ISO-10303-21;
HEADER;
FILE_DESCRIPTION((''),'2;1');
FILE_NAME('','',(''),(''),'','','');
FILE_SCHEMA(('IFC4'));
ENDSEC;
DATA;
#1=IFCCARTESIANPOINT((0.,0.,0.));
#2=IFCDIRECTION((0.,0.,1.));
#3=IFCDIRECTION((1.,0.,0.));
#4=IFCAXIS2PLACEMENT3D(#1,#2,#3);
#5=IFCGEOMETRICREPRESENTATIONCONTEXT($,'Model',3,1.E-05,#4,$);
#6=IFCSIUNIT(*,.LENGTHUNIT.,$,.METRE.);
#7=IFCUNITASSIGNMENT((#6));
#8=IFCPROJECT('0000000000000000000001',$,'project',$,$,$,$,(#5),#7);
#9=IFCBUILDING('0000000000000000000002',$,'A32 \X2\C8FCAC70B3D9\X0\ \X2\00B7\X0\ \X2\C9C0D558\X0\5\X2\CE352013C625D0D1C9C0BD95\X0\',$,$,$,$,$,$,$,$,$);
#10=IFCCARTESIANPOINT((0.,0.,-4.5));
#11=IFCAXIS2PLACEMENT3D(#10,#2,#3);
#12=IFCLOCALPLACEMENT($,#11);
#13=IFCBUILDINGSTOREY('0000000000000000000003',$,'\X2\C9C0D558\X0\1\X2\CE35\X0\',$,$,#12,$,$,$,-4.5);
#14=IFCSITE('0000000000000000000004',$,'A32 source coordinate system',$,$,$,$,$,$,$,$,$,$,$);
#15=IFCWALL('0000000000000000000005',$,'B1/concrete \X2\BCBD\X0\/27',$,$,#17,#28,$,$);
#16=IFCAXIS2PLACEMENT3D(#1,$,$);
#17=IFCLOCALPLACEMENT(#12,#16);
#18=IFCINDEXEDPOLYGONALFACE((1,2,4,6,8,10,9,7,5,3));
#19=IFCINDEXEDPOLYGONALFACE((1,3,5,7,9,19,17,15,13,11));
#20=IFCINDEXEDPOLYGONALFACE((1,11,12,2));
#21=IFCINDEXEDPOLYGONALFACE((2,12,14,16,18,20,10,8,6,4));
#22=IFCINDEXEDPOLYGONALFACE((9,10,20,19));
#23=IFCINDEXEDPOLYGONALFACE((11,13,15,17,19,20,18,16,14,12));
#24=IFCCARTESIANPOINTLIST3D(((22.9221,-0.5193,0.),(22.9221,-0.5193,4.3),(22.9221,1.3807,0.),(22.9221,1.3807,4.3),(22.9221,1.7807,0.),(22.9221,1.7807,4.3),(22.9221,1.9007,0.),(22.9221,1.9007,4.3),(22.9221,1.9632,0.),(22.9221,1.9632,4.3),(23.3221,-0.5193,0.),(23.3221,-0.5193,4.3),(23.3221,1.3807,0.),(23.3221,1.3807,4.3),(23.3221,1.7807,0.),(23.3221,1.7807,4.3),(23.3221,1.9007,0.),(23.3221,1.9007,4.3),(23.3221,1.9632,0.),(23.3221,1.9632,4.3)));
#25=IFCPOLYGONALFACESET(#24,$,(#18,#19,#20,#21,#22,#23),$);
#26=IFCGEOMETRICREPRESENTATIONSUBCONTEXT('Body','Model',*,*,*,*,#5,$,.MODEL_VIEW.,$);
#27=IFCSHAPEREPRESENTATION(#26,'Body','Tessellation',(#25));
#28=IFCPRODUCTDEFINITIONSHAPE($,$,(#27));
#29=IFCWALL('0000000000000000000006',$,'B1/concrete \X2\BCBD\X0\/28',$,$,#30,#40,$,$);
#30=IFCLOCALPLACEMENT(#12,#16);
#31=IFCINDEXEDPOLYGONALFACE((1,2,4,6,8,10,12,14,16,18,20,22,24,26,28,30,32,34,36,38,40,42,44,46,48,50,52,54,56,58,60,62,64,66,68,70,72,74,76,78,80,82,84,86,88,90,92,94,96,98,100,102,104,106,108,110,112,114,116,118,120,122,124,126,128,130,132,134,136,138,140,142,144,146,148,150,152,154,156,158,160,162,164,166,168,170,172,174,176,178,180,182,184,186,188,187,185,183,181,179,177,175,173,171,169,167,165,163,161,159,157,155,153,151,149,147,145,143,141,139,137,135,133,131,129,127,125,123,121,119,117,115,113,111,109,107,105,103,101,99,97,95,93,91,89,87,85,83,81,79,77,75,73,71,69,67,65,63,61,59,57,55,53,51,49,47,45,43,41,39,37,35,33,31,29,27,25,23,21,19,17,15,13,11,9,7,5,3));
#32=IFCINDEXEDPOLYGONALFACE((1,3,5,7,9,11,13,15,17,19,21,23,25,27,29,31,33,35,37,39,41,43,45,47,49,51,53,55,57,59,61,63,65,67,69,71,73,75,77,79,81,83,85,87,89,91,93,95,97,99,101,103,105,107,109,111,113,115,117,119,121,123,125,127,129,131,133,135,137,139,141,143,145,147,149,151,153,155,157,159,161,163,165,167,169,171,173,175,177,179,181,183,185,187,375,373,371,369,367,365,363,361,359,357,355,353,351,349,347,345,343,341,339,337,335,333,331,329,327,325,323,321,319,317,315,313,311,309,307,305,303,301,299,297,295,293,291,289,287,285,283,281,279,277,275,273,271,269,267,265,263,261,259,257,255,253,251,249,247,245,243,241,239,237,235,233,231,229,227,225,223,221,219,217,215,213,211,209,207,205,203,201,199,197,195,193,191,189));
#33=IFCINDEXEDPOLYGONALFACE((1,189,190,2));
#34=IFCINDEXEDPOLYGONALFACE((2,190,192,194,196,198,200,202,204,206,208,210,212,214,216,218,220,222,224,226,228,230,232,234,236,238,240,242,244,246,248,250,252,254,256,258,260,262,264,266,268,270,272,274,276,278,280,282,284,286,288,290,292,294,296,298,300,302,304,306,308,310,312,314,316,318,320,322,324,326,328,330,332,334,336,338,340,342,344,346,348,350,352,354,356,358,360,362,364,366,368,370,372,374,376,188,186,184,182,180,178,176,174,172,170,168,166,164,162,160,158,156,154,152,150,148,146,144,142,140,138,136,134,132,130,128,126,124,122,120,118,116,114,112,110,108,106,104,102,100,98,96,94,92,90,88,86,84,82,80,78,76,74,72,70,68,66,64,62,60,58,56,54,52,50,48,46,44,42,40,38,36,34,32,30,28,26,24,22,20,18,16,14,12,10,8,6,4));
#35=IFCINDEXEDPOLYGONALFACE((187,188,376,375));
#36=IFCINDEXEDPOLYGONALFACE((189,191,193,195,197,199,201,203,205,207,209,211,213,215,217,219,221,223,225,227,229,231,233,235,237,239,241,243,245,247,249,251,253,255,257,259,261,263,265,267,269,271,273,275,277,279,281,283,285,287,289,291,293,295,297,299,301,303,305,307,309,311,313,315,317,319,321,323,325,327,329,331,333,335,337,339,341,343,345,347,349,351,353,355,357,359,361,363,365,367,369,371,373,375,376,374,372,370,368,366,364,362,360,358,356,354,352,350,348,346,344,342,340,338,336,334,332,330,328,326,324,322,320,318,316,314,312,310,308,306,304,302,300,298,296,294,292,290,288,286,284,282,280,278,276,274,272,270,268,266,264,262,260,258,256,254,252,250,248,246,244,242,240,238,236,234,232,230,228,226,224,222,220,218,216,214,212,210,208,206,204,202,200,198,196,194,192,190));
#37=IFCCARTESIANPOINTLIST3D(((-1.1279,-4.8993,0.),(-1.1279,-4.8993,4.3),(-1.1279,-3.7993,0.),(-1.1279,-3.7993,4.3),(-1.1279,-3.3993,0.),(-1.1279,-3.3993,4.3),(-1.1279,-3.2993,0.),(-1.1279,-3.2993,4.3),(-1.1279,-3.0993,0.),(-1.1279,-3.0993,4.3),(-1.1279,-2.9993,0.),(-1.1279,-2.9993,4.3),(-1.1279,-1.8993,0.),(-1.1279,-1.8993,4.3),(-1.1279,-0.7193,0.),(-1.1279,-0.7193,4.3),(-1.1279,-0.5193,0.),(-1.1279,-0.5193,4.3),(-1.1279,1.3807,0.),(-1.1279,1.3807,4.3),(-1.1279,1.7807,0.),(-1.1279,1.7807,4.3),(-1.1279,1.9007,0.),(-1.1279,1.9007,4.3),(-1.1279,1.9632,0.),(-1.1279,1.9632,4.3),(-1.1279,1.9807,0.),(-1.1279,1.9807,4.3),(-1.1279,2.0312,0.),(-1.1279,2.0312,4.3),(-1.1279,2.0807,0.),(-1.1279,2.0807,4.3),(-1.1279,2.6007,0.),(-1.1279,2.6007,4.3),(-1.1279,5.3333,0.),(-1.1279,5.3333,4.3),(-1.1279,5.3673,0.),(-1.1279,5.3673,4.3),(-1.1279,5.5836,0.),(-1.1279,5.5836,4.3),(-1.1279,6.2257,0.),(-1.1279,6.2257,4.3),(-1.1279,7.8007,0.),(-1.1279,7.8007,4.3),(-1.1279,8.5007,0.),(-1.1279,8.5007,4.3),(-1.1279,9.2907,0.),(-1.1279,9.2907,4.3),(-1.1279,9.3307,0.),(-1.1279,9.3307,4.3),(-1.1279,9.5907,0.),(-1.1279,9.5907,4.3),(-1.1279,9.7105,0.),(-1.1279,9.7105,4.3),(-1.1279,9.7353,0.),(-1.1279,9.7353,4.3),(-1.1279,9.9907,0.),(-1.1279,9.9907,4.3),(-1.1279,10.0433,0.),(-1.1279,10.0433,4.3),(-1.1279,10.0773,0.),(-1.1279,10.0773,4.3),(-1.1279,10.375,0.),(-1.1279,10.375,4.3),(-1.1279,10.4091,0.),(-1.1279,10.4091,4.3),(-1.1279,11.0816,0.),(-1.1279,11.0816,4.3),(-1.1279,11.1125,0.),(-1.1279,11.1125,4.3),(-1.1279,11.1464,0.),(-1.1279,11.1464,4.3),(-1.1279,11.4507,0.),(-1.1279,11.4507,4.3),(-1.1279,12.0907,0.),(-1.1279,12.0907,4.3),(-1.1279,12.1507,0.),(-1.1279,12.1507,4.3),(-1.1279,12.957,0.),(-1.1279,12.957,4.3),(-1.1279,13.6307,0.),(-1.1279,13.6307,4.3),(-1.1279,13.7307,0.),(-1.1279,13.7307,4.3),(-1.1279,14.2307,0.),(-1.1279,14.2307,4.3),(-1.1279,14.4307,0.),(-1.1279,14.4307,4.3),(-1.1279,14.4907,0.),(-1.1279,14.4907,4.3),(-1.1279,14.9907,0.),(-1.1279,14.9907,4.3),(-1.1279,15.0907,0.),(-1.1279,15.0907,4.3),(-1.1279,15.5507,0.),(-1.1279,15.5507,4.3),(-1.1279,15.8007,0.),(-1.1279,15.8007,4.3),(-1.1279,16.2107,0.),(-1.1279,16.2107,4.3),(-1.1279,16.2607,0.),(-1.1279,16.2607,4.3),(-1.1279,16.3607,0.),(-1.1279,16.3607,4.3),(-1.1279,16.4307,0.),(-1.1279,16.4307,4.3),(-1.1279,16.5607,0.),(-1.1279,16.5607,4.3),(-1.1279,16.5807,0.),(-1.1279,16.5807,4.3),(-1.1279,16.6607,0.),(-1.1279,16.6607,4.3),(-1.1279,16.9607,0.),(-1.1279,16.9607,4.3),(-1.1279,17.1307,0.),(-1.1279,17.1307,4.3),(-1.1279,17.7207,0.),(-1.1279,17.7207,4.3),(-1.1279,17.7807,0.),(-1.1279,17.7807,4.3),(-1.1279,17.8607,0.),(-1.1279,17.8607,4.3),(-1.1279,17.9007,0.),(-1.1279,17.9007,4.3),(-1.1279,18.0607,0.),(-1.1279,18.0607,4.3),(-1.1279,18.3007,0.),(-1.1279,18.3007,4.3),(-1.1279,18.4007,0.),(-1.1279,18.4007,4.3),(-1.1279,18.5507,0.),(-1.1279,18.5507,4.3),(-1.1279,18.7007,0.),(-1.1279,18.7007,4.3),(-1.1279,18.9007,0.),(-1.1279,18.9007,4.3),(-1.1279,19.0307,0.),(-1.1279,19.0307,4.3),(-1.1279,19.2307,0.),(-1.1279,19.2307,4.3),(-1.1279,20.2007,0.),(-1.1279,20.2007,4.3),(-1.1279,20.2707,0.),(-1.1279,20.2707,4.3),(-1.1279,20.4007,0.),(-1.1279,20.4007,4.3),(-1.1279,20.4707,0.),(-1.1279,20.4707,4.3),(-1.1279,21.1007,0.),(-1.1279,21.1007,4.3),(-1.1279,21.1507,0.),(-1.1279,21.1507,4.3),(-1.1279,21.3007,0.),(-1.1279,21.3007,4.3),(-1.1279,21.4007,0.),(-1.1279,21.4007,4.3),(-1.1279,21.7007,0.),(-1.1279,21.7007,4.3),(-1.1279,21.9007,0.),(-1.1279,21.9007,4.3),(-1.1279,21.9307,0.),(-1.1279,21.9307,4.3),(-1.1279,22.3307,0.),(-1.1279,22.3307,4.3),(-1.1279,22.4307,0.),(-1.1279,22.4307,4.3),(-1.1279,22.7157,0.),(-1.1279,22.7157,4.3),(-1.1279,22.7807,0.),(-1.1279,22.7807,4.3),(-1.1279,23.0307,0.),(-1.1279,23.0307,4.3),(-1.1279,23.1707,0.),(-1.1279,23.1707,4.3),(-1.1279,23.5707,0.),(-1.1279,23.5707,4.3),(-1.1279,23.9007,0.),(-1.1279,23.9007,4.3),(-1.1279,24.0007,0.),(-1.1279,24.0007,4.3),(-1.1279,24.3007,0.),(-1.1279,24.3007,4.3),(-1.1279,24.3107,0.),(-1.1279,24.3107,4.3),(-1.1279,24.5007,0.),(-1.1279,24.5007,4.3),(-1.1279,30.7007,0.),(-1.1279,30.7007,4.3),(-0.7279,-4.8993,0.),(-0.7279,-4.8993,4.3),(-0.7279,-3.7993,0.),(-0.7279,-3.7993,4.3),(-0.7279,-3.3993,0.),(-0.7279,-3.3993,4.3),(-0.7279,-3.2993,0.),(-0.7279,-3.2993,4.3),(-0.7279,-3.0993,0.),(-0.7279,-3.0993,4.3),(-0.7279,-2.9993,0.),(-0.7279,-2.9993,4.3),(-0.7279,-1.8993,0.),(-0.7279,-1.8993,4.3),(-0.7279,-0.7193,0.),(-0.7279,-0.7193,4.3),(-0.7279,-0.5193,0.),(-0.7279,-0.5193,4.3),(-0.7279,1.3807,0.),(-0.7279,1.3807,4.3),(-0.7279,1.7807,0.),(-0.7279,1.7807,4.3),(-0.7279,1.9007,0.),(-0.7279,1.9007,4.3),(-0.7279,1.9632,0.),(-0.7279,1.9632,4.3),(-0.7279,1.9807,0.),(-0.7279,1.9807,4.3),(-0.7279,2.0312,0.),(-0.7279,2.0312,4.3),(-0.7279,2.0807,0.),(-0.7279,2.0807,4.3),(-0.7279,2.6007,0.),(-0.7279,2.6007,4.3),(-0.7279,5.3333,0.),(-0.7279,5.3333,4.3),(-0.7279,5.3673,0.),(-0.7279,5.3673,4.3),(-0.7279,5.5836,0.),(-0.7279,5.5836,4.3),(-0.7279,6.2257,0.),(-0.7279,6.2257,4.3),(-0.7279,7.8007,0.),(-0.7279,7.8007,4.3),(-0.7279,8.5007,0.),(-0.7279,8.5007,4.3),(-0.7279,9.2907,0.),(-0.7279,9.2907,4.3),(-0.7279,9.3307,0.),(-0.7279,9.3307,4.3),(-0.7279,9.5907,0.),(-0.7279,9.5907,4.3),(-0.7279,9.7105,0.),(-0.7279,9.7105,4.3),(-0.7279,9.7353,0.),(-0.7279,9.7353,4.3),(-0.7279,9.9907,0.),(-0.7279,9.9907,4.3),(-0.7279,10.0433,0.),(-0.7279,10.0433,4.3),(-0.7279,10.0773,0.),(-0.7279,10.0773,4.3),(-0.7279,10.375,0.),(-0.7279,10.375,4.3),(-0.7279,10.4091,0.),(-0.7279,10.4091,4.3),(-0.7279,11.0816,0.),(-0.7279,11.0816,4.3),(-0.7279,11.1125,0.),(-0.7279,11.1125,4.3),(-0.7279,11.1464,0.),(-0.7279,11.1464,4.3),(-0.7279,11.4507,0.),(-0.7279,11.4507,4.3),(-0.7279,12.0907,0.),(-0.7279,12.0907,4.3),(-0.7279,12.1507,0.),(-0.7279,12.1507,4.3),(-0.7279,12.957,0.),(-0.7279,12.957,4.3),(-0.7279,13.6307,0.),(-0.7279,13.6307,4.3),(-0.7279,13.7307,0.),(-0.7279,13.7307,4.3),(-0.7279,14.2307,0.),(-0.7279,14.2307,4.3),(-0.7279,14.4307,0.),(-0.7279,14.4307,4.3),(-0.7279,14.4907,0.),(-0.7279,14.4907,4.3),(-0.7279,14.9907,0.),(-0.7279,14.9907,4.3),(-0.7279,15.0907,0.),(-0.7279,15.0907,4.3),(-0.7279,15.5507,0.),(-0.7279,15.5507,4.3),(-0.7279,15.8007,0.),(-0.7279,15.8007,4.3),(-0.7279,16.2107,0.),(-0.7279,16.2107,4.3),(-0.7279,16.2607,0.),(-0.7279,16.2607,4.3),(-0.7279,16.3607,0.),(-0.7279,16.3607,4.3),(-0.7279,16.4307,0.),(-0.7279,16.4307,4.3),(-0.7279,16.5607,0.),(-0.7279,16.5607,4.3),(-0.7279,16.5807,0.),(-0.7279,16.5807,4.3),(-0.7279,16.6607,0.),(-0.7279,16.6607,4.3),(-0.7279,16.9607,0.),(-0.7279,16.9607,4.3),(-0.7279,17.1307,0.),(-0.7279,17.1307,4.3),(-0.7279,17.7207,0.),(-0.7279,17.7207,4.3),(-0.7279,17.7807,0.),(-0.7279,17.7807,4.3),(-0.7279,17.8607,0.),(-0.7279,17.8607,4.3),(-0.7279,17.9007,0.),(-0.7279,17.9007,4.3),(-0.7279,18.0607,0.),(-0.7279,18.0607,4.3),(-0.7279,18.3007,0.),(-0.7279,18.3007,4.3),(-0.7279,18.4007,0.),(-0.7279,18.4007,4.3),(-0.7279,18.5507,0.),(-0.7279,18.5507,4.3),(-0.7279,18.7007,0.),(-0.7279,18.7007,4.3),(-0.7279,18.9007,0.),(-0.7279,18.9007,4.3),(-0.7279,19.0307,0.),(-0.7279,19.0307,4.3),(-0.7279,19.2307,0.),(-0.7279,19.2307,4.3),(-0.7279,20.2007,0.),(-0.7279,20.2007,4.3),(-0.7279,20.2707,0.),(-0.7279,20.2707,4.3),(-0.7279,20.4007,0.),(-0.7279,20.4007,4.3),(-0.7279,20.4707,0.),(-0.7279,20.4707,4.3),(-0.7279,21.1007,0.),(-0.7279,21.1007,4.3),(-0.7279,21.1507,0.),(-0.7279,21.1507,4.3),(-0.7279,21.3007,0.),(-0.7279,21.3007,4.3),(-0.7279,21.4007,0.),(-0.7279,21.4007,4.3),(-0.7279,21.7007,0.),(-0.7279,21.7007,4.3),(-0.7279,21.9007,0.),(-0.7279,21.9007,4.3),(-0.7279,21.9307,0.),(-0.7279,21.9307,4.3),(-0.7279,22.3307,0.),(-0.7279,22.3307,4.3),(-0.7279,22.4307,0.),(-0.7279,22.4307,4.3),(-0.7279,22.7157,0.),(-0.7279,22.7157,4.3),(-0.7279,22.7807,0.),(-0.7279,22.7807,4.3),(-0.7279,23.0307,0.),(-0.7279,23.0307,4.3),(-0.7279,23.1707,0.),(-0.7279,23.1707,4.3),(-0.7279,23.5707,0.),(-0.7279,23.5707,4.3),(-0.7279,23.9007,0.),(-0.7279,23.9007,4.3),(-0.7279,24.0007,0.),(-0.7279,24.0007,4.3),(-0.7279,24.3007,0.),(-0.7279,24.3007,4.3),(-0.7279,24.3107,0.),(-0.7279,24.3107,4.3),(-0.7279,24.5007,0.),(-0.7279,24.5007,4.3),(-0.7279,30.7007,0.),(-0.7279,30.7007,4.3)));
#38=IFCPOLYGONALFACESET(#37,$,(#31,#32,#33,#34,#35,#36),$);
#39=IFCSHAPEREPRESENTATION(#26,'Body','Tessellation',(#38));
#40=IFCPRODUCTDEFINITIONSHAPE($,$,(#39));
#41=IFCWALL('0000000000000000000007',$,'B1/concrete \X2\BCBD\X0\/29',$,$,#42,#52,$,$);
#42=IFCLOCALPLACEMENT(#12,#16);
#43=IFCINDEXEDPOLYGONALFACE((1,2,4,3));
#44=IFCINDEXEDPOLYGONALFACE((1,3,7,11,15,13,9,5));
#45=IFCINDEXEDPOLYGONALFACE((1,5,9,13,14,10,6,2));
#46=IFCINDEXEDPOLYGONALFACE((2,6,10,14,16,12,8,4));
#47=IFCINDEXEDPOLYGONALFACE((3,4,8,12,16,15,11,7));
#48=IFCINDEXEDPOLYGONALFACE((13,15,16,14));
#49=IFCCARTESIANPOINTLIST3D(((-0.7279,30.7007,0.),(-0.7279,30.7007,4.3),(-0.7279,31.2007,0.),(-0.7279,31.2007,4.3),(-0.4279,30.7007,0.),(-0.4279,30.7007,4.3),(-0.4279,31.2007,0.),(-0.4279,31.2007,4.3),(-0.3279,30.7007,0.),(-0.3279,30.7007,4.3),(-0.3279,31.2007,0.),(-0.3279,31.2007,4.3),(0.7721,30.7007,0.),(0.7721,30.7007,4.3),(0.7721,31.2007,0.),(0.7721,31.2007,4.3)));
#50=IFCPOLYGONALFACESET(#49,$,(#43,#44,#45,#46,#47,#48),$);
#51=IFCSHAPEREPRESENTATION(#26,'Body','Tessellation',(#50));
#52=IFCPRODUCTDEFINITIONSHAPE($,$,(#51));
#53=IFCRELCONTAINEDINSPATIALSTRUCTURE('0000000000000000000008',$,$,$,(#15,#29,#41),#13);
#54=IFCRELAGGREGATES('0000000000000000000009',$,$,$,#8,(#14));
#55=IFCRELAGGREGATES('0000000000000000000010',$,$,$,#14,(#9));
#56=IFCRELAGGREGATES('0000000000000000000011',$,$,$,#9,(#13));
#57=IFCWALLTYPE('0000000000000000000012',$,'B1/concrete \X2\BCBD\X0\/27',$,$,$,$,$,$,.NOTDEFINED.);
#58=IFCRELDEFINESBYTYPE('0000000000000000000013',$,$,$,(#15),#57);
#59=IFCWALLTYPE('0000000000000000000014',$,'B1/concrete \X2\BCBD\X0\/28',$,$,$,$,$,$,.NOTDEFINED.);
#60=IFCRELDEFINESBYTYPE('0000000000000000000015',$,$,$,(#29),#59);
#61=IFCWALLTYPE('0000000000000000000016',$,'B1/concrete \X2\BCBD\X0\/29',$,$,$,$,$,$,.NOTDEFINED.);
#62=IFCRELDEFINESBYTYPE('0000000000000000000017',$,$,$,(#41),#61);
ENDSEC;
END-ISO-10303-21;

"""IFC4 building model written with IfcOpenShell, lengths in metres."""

from ifc_helpers import new_model, si_unit, frame, origin, origin_with_axes, place, context, subcontext, project, spatial, polyline, outline, extrude, source, transform, mapped, type_object, type_shapes, element, save


model = new_model("IFC4")

# Units and contexts
model_context = context("Model", 3, precision=1e-05, world=origin_with_axes())
body_context = subcontext(model_context, "Body", "Model", "MODEL_VIEW")
ifc_project = project(units=[si_unit("LENGTHUNIT", "METRE")], contexts=[model_context])

# Site, building, storey
site = spatial("IfcSite", under=ifc_project, Name="A32 source coordinate system")
building = spatial("IfcBuilding", under=site, Name="A32 주거동 · 지하5층–옥탑지붕")
storey_placement = place(None, frame((0.0, 0.0, -4.5), z_axis=(0.0, 0.0, 1.0), x_axis=(1.0, 0.0, 0.0)))
storey = spatial("IfcBuildingStorey", under=building, at=storey_placement, Name="지하1층", Elevation=-4.5)

# Walls
wall_type_1 = type_object("IfcWallType", Name="B1/concrete 벽/27", PredefinedType="NOTDEFINED")
shared_shape_1 = source(origin(), body_context, "Body", "SweptSolid", [
    extrude(outline(polyline([(22.9221, 1.9007), (22.9221, 1.9632), (23.3221, 1.9632), (23.3221, 1.9007), (23.3221, 1.7807), (23.3221, 1.3807), (23.3221, -0.5193), (22.9221, -0.5193), (22.9221, 1.3807), (22.9221, 1.7807), (22.9221, 1.9007)])), origin(), (0.0, 0.0, 1.0), 4.3),
])
type_shapes(wall_type_1, [shared_shape_1])
wall_1_placement = place(storey_placement, origin_with_axes())
element("IfcWall", 1, at=wall_1_placement, inside=storey, type_object=wall_type_1, Name="B1/concrete 벽/27", context=body_context, shape_type="MappedRepresentation", body=[
    mapped(shared_shape_1, transform((0.0, 0.0, 0.0), scale=1.0)),
])
wall_type_2 = type_object("IfcWallType", Name="B1/concrete 벽/28", PredefinedType="NOTDEFINED")
shared_shape_2 = source(origin(), body_context, "Body", "SweptSolid", [
    extrude(outline(polyline([(-1.1279, -3.3993), (-1.1279, -3.2993), (-1.1279, -3.0993), (-1.1279, -2.9993), (-1.1279, -1.8993), (-1.1279, -0.7193), (-1.1279, -0.5193), (-1.1279, 1.3807), (-1.1279, 1.7807), (-1.1279, 1.9007), (-1.1279, 1.9632), (-1.1279, 1.9807), (-1.1279, 2.0312), (-1.1279, 2.0807), (-1.1279, 2.6007), (-1.1279, 5.3333), (-1.1279, 5.3673), (-1.1279, 5.5836), (-1.1279, 6.2257), (-1.1279, 7.8007), (-1.1279, 8.5007), (-1.1279, 9.2907), (-1.1279, 9.3307), (-1.1279, 9.5907), (-1.1279, 9.7105), (-1.1279, 9.7353), (-1.1279, 9.9907), (-1.1279, 10.0433), (-1.1279, 10.0773), (-1.1279, 10.375), (-1.1279, 10.4091), (-1.1279, 11.0816), (-1.1279, 11.1125), (-1.1279, 11.1464), (-1.1279, 11.4507), (-1.1279, 12.0907), (-1.1279, 12.1507), (-1.1279, 12.957), (-1.1279, 13.6307), (-1.1279, 13.7307), (-1.1279, 14.2307), (-1.1279, 14.4307), (-1.1279, 14.4907), (-1.1279, 14.9907), (-1.1279, 15.0907), (-1.1279, 15.5507), (-1.1279, 15.8007), (-1.1279, 16.2107), (-1.1279, 16.2607), (-1.1279, 16.3607), (-1.1279, 16.4307), (-1.1279, 16.5607), (-1.1279, 16.5807), (-1.1279, 16.6607), (-1.1279, 16.9607), (-1.1279, 17.1307), (-1.1279, 17.7207), (-1.1279, 17.7807), (-1.1279, 17.8607), (-1.1279, 17.9007), (-1.1279, 18.0607), (-1.1279, 18.3007), (-1.1279, 18.4007), (-1.1279, 18.5507), (-1.1279, 18.7007), (-1.1279, 18.9007), (-1.1279, 19.0307), (-1.1279, 19.2307), (-1.1279, 20.2007), (-1.1279, 20.2707), (-1.1279, 20.4007), (-1.1279, 20.4707), (-1.1279, 21.1007), (-1.1279, 21.1507), (-1.1279, 21.3007), (-1.1279, 21.4007), (-1.1279, 21.7007), (-1.1279, 21.9007), (-1.1279, 21.9307), (-1.1279, 22.3307), (-1.1279, 22.4307), (-1.1279, 22.7157), (-1.1279, 22.7807), (-1.1279, 23.0307), (-1.1279, 23.1707), (-1.1279, 23.5707), (-1.1279, 23.9007), (-1.1279, 24.0007), (-1.1279, 24.3007), (-1.1279, 24.3107), (-1.1279, 24.5007), (-1.1279, 30.7007), (-0.7279, 30.7007), (-0.7279, 24.5007), (-0.7279, 24.3107), (-0.7279, 24.3007), (-0.7279, 24.0007), (-0.7279, 23.9007), (-0.7279, 23.5707), (-0.7279, 23.1707), (-0.7279, 23.0307), (-0.7279, 22.7807), (-0.7279, 22.7157), (-0.7279, 22.4307), (-0.7279, 22.3307), (-0.7279, 21.9307), (-0.7279, 21.9007), (-0.7279, 21.7007), (-0.7279, 21.4007), (-0.7279, 21.3007), (-0.7279, 21.1507), (-0.7279, 21.1007), (-0.7279, 20.4707), (-0.7279, 20.4007), (-0.7279, 20.2707), (-0.7279, 20.2007), (-0.7279, 19.2307), (-0.7279, 19.0307), (-0.7279, 18.9007), (-0.7279, 18.7007), (-0.7279, 18.5507), (-0.7279, 18.4007), (-0.7279, 18.3007), (-0.7279, 18.0607), (-0.7279, 17.9007), (-0.7279, 17.8607), (-0.7279, 17.7807), (-0.7279, 17.7207), (-0.7279, 17.1307), (-0.7279, 16.9607), (-0.7279, 16.6607), (-0.7279, 16.5807), (-0.7279, 16.5607), (-0.7279, 16.4307), (-0.7279, 16.3607), (-0.7279, 16.2607), (-0.7279, 16.2107), (-0.7279, 15.8007), (-0.7279, 15.5507), (-0.7279, 15.0907), (-0.7279, 14.9907), (-0.7279, 14.4907), (-0.7279, 14.4307), (-0.7279, 14.2307), (-0.7279, 13.7307), (-0.7279, 13.6307), (-0.7279, 12.957), (-0.7279, 12.1507), (-0.7279, 12.0907), (-0.7279, 11.4507), (-0.7279, 11.1464), (-0.7279, 11.1125), (-0.7279, 11.0816), (-0.7279, 10.4091), (-0.7279, 10.375), (-0.7279, 10.0773), (-0.7279, 10.0433), (-0.7279, 9.9907), (-0.7279, 9.7353), (-0.7279, 9.7105), (-0.7279, 9.5907), (-0.7279, 9.3307), (-0.7279, 9.2907), (-0.7279, 8.5007), (-0.7279, 7.8007), (-0.7279, 6.2257), (-0.7279, 5.5836), (-0.7279, 5.3673), (-0.7279, 5.3333), (-0.7279, 2.6007), (-0.7279, 2.0807), (-0.7279, 2.0312), (-0.7279, 1.9807), (-0.7279, 1.9632), (-0.7279, 1.9007), (-0.7279, 1.7807), (-0.7279, 1.3807), (-0.7279, -0.5193), (-0.7279, -0.7193), (-0.7279, -1.8993), (-0.7279, -2.9993), (-0.7279, -3.0993), (-0.7279, -3.2993), (-0.7279, -3.3993), (-0.7279, -3.7993), (-0.7279, -4.8993), (-1.1279, -4.8993), (-1.1279, -3.7993), (-1.1279, -3.3993)])), origin(), (0.0, 0.0, 1.0), 4.3),
])
type_shapes(wall_type_2, [shared_shape_2])
wall_2_placement = place(storey_placement, origin_with_axes())
element("IfcWall", 2, at=wall_2_placement, inside=storey, type_object=wall_type_2, Name="B1/concrete 벽/28", context=body_context, shape_type="MappedRepresentation", body=[
    mapped(shared_shape_2, transform((0.0, 0.0, 0.0), scale=1.0)),
])
wall_type_3 = type_object("IfcWallType", Name="B1/concrete 벽/29", PredefinedType="NOTDEFINED")
shared_shape_3 = source(origin(), body_context, "Body", "SweptSolid", [
    extrude(outline(polyline([(-0.3279, 31.2007), (0.7721, 31.2007), (0.7721, 30.7007), (-0.3279, 30.7007), (-0.4279, 30.7007), (-0.7279, 30.7007), (-0.7279, 31.2007), (-0.4279, 31.2007), (-0.3279, 31.2007)])), origin(), (0.0, 0.0, 1.0), 4.3),
])
type_shapes(wall_type_3, [shared_shape_3])
wall_3_placement = place(storey_placement, origin_with_axes())
element("IfcWall", 3, at=wall_3_placement, inside=storey, type_object=wall_type_3, Name="B1/concrete 벽/29", context=body_context, shape_type="MappedRepresentation", body=[
    mapped(shared_shape_3, transform((0.0, 0.0, 0.0), scale=1.0)),
])

save(model, "model.ifc")
